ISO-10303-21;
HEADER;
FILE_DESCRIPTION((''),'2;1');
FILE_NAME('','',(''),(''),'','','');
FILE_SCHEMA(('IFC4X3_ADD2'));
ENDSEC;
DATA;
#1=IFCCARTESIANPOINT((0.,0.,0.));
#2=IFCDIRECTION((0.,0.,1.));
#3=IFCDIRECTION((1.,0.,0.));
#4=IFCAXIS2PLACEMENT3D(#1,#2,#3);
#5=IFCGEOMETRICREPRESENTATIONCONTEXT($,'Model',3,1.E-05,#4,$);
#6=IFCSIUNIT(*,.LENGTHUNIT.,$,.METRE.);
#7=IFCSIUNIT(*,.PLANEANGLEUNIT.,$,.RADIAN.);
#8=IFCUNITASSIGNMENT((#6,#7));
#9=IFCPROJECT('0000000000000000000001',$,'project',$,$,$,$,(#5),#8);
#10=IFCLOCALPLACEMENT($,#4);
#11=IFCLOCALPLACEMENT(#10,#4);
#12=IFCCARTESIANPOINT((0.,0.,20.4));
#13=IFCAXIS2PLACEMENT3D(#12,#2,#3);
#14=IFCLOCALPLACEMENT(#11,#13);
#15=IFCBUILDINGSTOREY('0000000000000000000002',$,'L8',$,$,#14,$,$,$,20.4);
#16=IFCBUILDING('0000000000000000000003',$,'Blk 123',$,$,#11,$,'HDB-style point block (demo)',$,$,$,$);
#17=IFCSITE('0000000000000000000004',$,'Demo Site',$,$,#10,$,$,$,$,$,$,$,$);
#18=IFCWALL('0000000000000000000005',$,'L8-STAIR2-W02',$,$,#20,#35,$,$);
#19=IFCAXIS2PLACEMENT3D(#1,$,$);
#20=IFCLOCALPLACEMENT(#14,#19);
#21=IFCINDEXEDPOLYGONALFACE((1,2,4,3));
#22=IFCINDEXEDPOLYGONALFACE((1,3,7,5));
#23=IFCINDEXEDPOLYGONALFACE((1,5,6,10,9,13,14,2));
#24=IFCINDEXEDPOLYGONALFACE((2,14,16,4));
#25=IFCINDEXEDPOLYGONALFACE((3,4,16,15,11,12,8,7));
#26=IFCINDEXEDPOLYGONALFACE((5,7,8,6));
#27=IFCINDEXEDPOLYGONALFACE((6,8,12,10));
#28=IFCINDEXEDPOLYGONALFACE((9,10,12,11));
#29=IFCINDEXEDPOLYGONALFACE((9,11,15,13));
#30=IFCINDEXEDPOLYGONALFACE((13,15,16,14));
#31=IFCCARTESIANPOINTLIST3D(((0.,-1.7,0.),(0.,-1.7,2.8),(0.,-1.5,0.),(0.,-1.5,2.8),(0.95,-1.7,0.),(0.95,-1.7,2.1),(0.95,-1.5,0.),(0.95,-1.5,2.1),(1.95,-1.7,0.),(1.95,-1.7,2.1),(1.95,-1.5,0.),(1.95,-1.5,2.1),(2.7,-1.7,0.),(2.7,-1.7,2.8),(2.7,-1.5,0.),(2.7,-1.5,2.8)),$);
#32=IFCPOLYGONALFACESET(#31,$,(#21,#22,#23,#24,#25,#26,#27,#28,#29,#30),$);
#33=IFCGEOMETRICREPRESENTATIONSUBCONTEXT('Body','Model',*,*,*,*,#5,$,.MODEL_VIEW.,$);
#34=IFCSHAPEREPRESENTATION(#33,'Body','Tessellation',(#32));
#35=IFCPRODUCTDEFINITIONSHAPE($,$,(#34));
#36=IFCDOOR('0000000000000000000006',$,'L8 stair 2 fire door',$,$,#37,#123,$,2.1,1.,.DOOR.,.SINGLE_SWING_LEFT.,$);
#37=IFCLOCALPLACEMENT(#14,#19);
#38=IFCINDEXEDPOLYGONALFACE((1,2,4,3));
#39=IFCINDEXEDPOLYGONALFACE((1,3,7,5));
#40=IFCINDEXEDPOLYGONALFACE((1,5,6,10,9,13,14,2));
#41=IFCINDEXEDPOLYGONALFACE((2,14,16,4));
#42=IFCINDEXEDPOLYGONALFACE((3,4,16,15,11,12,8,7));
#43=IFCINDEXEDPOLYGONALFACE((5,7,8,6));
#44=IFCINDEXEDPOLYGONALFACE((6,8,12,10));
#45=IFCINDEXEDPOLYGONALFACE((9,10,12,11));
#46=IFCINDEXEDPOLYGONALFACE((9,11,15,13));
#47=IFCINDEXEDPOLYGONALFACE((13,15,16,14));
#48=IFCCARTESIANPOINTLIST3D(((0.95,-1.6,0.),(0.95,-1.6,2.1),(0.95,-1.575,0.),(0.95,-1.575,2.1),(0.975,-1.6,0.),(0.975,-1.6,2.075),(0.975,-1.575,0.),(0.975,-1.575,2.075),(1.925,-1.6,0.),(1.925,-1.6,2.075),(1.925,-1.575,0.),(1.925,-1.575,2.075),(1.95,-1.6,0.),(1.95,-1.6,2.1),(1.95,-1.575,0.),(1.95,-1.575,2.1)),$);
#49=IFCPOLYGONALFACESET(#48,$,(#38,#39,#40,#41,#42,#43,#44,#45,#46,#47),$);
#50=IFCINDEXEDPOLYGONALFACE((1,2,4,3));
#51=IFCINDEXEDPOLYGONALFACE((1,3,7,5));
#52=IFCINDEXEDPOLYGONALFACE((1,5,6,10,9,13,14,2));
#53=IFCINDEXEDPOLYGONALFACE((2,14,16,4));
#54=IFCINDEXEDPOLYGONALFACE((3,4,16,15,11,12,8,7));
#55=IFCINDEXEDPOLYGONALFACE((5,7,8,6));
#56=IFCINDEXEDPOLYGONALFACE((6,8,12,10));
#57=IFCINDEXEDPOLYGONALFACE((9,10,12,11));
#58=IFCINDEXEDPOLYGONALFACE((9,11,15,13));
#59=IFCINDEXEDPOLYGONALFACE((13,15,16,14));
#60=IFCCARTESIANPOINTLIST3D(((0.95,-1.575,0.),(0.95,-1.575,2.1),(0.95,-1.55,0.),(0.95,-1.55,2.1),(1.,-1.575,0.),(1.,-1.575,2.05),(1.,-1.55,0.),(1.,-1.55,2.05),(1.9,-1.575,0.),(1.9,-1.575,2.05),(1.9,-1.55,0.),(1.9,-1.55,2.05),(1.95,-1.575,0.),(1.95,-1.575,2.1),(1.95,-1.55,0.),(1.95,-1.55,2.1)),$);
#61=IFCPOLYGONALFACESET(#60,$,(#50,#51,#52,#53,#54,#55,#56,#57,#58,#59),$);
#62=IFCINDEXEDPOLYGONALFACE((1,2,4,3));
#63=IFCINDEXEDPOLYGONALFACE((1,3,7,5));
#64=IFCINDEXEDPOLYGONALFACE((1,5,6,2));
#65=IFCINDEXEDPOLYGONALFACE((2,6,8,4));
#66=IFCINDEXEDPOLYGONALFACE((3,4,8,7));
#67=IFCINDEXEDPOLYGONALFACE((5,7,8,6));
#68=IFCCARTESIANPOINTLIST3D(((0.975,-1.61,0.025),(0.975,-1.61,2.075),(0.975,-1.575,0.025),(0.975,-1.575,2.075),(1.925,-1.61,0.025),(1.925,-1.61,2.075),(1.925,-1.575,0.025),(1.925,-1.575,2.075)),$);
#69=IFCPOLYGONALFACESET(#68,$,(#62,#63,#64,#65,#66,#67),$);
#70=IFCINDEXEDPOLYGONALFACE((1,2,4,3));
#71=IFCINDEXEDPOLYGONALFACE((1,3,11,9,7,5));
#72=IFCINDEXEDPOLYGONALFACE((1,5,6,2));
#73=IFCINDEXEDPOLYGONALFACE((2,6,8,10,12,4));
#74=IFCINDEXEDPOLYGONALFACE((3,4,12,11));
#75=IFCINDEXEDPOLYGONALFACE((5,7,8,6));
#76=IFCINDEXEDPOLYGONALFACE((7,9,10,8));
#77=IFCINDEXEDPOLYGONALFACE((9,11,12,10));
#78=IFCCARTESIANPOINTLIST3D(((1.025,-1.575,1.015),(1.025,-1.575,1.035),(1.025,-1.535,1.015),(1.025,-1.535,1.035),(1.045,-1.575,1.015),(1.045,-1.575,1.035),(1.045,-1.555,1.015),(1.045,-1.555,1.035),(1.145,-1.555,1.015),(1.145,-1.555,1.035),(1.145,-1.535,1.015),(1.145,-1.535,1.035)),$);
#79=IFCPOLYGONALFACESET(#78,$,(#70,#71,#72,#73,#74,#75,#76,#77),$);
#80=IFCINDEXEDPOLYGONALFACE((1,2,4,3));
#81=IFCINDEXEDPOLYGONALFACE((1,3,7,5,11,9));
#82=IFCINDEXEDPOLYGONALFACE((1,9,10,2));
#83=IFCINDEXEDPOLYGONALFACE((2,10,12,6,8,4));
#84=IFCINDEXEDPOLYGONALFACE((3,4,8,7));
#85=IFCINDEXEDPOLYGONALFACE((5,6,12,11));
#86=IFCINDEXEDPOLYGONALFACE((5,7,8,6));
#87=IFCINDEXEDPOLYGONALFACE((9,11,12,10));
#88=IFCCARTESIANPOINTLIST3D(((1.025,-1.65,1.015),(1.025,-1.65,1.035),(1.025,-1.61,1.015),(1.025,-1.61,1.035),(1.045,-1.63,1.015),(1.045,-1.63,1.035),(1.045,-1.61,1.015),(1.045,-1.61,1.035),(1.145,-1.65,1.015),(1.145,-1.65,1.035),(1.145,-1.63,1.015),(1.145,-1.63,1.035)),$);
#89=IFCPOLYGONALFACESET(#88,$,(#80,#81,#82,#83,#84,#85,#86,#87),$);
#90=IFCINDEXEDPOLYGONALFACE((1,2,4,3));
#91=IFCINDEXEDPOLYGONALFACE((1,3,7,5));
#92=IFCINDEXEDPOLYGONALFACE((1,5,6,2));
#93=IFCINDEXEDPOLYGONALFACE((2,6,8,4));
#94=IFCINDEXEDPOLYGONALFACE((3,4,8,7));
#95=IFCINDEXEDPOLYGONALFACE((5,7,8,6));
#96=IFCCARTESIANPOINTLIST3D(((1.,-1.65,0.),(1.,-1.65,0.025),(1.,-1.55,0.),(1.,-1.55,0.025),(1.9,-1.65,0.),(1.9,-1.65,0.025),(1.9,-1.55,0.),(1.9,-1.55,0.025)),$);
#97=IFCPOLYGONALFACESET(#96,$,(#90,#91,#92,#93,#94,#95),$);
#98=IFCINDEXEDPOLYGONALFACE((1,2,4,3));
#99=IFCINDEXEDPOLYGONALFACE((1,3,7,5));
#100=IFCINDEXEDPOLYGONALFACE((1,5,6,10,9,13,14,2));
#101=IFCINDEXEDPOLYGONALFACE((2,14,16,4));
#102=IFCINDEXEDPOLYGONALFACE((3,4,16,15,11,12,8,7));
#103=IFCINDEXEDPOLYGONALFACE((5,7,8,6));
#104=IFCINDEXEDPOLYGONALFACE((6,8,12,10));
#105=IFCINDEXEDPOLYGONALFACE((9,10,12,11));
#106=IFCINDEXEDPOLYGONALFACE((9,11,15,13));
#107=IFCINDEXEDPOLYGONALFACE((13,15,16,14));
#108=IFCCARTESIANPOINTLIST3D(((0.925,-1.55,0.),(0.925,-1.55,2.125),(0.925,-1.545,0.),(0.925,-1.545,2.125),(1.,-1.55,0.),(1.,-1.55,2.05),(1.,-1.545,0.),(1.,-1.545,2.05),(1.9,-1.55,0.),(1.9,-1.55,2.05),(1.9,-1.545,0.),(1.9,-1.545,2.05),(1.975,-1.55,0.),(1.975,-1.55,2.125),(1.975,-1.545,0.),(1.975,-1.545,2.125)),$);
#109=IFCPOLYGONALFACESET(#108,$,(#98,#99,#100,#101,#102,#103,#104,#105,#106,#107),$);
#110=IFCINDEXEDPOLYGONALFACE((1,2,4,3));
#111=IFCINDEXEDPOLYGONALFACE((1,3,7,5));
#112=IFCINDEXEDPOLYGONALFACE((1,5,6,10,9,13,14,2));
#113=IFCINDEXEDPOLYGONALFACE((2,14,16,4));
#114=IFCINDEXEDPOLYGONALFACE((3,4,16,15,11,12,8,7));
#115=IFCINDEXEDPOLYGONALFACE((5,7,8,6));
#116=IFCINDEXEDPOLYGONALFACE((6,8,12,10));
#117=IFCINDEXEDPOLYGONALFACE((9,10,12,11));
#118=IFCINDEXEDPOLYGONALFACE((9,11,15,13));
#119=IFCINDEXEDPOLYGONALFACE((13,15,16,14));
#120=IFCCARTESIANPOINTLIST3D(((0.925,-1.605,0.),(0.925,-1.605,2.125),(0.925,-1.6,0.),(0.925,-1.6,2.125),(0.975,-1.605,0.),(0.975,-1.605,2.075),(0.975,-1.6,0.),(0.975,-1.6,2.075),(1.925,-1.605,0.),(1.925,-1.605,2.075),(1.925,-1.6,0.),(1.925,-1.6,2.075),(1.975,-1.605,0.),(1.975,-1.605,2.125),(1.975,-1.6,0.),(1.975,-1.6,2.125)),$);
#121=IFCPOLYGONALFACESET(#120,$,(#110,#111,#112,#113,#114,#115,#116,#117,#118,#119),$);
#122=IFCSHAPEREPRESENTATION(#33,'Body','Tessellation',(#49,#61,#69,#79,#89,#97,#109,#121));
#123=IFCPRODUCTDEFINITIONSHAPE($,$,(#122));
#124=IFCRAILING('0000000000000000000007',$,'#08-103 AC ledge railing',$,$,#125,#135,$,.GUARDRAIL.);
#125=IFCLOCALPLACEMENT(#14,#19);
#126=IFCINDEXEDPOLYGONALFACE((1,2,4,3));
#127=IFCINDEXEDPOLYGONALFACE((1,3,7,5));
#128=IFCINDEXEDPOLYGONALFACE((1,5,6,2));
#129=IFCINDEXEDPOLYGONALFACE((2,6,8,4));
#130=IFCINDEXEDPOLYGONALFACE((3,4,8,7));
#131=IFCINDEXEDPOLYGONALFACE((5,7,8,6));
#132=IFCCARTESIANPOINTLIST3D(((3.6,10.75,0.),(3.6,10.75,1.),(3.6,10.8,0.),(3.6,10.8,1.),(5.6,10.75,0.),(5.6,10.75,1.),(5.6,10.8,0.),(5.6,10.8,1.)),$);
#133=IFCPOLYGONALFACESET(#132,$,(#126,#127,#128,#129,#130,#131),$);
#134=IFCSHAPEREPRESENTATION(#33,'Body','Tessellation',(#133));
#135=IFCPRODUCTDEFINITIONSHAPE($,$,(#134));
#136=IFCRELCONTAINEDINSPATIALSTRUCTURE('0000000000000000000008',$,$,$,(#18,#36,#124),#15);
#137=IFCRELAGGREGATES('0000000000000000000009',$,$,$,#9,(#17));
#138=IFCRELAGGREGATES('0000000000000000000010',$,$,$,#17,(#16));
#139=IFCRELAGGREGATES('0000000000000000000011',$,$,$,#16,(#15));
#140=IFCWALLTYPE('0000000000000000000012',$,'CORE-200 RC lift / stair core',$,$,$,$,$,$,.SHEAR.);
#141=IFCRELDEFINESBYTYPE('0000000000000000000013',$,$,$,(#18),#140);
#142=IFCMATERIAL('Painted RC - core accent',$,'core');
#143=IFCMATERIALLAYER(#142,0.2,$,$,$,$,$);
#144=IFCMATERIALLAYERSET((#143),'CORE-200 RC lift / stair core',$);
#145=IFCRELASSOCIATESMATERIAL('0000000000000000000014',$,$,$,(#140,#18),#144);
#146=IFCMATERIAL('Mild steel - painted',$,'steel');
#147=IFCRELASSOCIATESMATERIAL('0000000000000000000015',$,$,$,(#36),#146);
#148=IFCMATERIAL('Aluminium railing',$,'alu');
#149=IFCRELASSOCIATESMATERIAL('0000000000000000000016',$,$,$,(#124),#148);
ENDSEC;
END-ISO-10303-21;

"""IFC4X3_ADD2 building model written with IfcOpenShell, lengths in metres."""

from ifc_helpers import new_model, si_unit, frame, origin, origin_with_axes, place, context, subcontext, project, spatial, polyline, line, indexed_curve, outline, extrude, material, layer, layer_set, layer_usage, type_object, element, fill, save


model = new_model("IFC4X3_ADD2")

# Units and contexts
model_context = context("Model", 3, precision=1e-05, world=origin_with_axes())
body_context = subcontext(model_context, "Body", "Model", "MODEL_VIEW")
ifc_project = project(units=[si_unit("LENGTHUNIT", "METRE"), si_unit("PLANEANGLEUNIT", "RADIAN")], contexts=[model_context])

# Site, building, storey
site_placement = place(None, origin_with_axes())
site = spatial("IfcSite", under=ifc_project, at=site_placement, Name="Demo Site")
building_placement = place(site_placement, origin_with_axes())
building = spatial("IfcBuilding", under=site, at=building_placement, Name="Blk 123", LongName="HDB-style point block (demo)")
storey_placement = place(building_placement, frame((0.0, 0.0, 20.4), z_axis=(0.0, 0.0, 1.0), x_axis=(1.0, 0.0, 0.0)))
storey = spatial("IfcBuildingStorey", under=building, at=storey_placement, Name="L8", Elevation=20.4)

# Shared definitions
ifc_material_1 = material(Name="Painted RC - core accent", Category="core")
ifc_layer_1 = layer(ifc_material_1, 0.2)
ifc_layer_set_1 = layer_set([ifc_layer_1], Name="CORE-200 RC lift / stair core")
ifc_layer_usage_1 = layer_usage(ifc_layer_set_1, "AXIS2", "POSITIVE", 0.0)
wall_type_1 = type_object("IfcWallType", Name="CORE-200 RC lift / stair core", PredefinedType="SHEAR", material=ifc_layer_set_1)

# Wall, opening, door
wall_1_placement = place(storey_placement, frame((2.7, -1.5, 0.0), z_axis=(0.0, 0.0, 1.0), x_axis=(-1.0, 0.0, 0.0)))
wall_1 = element("IfcWall", 1, at=wall_1_placement, inside=storey, type_object=wall_type_1, material=ifc_layer_usage_1, Name="L8-STAIR2-W02", context=body_context, shape_type="SweptSolid", body=[
    extrude(outline(indexed_curve([(0.0, 0.0), (0.0, 0.2), (2.7, 0.2), (2.7, 0.0), (0.0, 0.0)], self_intersect=False)), origin_with_axes(), (0.0, 0.0, 1.0), 2.8),
])
opening_1_placement = place(wall_1_placement, frame((0.75, -0.1, 0.0), z_axis=(0.0, 0.0, 1.0), x_axis=(1.0, 0.0, 0.0)))
opening_1 = element("IfcOpeningElement", 2, at=opening_1_placement, cuts=wall_1, context=body_context, shape_type="SweptSolid", body=[
    extrude(outline(indexed_curve([(0.0, 0.0), (0.0, 0.4), (1.0, 0.4), (1.0, 0.0), (0.0, 0.0)], self_intersect=False)), origin_with_axes(), (0.0, 0.0, 1.0), 2.1),
])
ifc_material_2 = material(Name="Mild steel - painted", Category="steel")
door_1_placement = place(opening_1_placement, frame((0.0, 0.15, 0.0), z_axis=(0.0, 0.0, 1.0), x_axis=(1.0, 0.0, 0.0)))
door_1 = element("IfcDoor", 3, at=door_1_placement, inside=storey, material=ifc_material_2, Name="L8 stair 2 fire door", OperationType="SINGLE_SWING_LEFT", OverallHeight=2.1, OverallWidth=1.0, PredefinedType="DOOR", context=body_context, shape_type="SweptSolid", body=[
    extrude(outline(indexed_curve([(0.0, 0.0), (0.0, 2.1), (1.0, 2.1), (1.0, 0.0), (0.975, 0.0), (0.975, 2.075), (0.025, 2.075), (0.025, 0.0)], segments=[line(1, 2, 3, 4, 5, 6, 7, 8, 1)])), frame((0.0, 0.025, 0.0), z_axis=(0.0, -1.0, 0.0), x_axis=(1.0, 0.0, 0.0)), (0.0, 0.0, -1.0), 0.025),
    extrude(outline(indexed_curve([(0.0, 0.0), (0.0, 2.1), (1.0, 2.1), (1.0, 0.0), (0.95, 0.0), (0.95, 2.05), (0.05, 2.05), (0.05, 0.0)], segments=[line(1, 2, 3, 4, 5, 6, 7, 8, 1)])), frame((0.0, 0.0, 0.0), z_axis=(0.0, -1.0, 0.0), x_axis=(1.0, 0.0, 0.0)), (0.0, 0.0, -1.0), 0.025),
    extrude(outline(indexed_curve([(0.0, 0.0), (0.95, 0.0), (0.95, 0.035), (0.0, 0.035)], segments=[line(1, 2, 3, 4, 1)])), frame((0.025, 0.025, 0.025), z_axis=(0.0, 0.0, 1.0), x_axis=(1.0, 0.0, 0.0)), (0.0, 0.0, 1.0), 2.05),
    extrude(outline(indexed_curve([(0.0, 0.0), (0.0, -0.04), (-0.12, -0.04), (-0.12, -0.02), (-0.02, -0.02), (-0.02, 0.0)], segments=[line(1, 2, 3, 4, 5, 6, 1)])), frame((0.925, 0.025, 1.015), z_axis=(0.0, 0.0, 1.0), x_axis=(1.0, 0.0, 0.0)), (0.0, 0.0, 1.0), 0.02),
    extrude(outline(indexed_curve([(0.0, 0.0), (0.0, 0.04), (-0.12, 0.04), (-0.12, 0.02), (-0.02, 0.02), (-0.02, 0.0)], segments=[line(1, 2, 3, 4, 5, 6, 1)])), frame((0.925, 0.06, 1.015), z_axis=(0.0, 0.0, 1.0), x_axis=(1.0, 0.0, 0.0)), (0.0, 0.0, 1.0), 0.02),
    extrude(outline(indexed_curve([(0.0, 0.0), (0.9, 0.0), (0.9, 0.1), (0.0, 0.1)], segments=[line(1, 2, 3, 4, 1)])), frame((0.05, 0.0, 0.0), z_axis=(0.0, 0.0, 1.0), x_axis=(1.0, 0.0, 0.0)), (0.0, 0.0, 1.0), 0.025),
    extrude(outline(indexed_curve([(0.0, 0.0), (0.0, 2.125), (1.05, 2.125), (1.05, 0.0), (0.975, 0.0), (0.975, 2.05), (0.075, 2.05), (0.075, 0.0)], segments=[line(1, 2, 3, 4, 5, 6, 7, 8, 1)])), frame((-0.025, -0.005, 0.0), z_axis=(0.0, -1.0, 0.0), x_axis=(1.0, 0.0, 0.0)), (0.0, 0.0, -1.0), 0.005),
    extrude(outline(indexed_curve([(0.0, 0.0), (0.0, 2.125), (1.05, 2.125), (1.05, 0.0), (1.0, 0.0), (1.0, 2.075), (0.05, 2.075), (0.05, 0.0)], segments=[line(1, 2, 3, 4, 5, 6, 7, 8, 1)])), frame((-0.025, 0.05, 0.0), z_axis=(0.0, -1.0, 0.0), x_axis=(1.0, 0.0, 0.0)), (0.0, 0.0, -1.0), 0.005),
])
fill(opening_1, door_1)

# Railing
ifc_material_3 = material(Name="Aluminium railing", Category="alu")
railing_placement = place(storey_placement, frame((4.6, 10.775, 0.0), z_axis=(0.0, 0.0, 1.0), x_axis=(1.0, 0.0, 0.0)))
element("IfcRailing", 4, at=railing_placement, inside=storey, material=ifc_material_3, Name="#08-103 AC ledge railing", PredefinedType="GUARDRAIL", context=body_context, shape_type="SweptSolid", body=[
    extrude(outline(polyline([(1.0, -0.025), (1.0, 0.025), (-1.0, 0.025), (-1.0, -0.025), (1.0, -0.025)])), origin(), (0.0, 0.0, 1.0), 1.0),
])

save(model, "model.ifc")
